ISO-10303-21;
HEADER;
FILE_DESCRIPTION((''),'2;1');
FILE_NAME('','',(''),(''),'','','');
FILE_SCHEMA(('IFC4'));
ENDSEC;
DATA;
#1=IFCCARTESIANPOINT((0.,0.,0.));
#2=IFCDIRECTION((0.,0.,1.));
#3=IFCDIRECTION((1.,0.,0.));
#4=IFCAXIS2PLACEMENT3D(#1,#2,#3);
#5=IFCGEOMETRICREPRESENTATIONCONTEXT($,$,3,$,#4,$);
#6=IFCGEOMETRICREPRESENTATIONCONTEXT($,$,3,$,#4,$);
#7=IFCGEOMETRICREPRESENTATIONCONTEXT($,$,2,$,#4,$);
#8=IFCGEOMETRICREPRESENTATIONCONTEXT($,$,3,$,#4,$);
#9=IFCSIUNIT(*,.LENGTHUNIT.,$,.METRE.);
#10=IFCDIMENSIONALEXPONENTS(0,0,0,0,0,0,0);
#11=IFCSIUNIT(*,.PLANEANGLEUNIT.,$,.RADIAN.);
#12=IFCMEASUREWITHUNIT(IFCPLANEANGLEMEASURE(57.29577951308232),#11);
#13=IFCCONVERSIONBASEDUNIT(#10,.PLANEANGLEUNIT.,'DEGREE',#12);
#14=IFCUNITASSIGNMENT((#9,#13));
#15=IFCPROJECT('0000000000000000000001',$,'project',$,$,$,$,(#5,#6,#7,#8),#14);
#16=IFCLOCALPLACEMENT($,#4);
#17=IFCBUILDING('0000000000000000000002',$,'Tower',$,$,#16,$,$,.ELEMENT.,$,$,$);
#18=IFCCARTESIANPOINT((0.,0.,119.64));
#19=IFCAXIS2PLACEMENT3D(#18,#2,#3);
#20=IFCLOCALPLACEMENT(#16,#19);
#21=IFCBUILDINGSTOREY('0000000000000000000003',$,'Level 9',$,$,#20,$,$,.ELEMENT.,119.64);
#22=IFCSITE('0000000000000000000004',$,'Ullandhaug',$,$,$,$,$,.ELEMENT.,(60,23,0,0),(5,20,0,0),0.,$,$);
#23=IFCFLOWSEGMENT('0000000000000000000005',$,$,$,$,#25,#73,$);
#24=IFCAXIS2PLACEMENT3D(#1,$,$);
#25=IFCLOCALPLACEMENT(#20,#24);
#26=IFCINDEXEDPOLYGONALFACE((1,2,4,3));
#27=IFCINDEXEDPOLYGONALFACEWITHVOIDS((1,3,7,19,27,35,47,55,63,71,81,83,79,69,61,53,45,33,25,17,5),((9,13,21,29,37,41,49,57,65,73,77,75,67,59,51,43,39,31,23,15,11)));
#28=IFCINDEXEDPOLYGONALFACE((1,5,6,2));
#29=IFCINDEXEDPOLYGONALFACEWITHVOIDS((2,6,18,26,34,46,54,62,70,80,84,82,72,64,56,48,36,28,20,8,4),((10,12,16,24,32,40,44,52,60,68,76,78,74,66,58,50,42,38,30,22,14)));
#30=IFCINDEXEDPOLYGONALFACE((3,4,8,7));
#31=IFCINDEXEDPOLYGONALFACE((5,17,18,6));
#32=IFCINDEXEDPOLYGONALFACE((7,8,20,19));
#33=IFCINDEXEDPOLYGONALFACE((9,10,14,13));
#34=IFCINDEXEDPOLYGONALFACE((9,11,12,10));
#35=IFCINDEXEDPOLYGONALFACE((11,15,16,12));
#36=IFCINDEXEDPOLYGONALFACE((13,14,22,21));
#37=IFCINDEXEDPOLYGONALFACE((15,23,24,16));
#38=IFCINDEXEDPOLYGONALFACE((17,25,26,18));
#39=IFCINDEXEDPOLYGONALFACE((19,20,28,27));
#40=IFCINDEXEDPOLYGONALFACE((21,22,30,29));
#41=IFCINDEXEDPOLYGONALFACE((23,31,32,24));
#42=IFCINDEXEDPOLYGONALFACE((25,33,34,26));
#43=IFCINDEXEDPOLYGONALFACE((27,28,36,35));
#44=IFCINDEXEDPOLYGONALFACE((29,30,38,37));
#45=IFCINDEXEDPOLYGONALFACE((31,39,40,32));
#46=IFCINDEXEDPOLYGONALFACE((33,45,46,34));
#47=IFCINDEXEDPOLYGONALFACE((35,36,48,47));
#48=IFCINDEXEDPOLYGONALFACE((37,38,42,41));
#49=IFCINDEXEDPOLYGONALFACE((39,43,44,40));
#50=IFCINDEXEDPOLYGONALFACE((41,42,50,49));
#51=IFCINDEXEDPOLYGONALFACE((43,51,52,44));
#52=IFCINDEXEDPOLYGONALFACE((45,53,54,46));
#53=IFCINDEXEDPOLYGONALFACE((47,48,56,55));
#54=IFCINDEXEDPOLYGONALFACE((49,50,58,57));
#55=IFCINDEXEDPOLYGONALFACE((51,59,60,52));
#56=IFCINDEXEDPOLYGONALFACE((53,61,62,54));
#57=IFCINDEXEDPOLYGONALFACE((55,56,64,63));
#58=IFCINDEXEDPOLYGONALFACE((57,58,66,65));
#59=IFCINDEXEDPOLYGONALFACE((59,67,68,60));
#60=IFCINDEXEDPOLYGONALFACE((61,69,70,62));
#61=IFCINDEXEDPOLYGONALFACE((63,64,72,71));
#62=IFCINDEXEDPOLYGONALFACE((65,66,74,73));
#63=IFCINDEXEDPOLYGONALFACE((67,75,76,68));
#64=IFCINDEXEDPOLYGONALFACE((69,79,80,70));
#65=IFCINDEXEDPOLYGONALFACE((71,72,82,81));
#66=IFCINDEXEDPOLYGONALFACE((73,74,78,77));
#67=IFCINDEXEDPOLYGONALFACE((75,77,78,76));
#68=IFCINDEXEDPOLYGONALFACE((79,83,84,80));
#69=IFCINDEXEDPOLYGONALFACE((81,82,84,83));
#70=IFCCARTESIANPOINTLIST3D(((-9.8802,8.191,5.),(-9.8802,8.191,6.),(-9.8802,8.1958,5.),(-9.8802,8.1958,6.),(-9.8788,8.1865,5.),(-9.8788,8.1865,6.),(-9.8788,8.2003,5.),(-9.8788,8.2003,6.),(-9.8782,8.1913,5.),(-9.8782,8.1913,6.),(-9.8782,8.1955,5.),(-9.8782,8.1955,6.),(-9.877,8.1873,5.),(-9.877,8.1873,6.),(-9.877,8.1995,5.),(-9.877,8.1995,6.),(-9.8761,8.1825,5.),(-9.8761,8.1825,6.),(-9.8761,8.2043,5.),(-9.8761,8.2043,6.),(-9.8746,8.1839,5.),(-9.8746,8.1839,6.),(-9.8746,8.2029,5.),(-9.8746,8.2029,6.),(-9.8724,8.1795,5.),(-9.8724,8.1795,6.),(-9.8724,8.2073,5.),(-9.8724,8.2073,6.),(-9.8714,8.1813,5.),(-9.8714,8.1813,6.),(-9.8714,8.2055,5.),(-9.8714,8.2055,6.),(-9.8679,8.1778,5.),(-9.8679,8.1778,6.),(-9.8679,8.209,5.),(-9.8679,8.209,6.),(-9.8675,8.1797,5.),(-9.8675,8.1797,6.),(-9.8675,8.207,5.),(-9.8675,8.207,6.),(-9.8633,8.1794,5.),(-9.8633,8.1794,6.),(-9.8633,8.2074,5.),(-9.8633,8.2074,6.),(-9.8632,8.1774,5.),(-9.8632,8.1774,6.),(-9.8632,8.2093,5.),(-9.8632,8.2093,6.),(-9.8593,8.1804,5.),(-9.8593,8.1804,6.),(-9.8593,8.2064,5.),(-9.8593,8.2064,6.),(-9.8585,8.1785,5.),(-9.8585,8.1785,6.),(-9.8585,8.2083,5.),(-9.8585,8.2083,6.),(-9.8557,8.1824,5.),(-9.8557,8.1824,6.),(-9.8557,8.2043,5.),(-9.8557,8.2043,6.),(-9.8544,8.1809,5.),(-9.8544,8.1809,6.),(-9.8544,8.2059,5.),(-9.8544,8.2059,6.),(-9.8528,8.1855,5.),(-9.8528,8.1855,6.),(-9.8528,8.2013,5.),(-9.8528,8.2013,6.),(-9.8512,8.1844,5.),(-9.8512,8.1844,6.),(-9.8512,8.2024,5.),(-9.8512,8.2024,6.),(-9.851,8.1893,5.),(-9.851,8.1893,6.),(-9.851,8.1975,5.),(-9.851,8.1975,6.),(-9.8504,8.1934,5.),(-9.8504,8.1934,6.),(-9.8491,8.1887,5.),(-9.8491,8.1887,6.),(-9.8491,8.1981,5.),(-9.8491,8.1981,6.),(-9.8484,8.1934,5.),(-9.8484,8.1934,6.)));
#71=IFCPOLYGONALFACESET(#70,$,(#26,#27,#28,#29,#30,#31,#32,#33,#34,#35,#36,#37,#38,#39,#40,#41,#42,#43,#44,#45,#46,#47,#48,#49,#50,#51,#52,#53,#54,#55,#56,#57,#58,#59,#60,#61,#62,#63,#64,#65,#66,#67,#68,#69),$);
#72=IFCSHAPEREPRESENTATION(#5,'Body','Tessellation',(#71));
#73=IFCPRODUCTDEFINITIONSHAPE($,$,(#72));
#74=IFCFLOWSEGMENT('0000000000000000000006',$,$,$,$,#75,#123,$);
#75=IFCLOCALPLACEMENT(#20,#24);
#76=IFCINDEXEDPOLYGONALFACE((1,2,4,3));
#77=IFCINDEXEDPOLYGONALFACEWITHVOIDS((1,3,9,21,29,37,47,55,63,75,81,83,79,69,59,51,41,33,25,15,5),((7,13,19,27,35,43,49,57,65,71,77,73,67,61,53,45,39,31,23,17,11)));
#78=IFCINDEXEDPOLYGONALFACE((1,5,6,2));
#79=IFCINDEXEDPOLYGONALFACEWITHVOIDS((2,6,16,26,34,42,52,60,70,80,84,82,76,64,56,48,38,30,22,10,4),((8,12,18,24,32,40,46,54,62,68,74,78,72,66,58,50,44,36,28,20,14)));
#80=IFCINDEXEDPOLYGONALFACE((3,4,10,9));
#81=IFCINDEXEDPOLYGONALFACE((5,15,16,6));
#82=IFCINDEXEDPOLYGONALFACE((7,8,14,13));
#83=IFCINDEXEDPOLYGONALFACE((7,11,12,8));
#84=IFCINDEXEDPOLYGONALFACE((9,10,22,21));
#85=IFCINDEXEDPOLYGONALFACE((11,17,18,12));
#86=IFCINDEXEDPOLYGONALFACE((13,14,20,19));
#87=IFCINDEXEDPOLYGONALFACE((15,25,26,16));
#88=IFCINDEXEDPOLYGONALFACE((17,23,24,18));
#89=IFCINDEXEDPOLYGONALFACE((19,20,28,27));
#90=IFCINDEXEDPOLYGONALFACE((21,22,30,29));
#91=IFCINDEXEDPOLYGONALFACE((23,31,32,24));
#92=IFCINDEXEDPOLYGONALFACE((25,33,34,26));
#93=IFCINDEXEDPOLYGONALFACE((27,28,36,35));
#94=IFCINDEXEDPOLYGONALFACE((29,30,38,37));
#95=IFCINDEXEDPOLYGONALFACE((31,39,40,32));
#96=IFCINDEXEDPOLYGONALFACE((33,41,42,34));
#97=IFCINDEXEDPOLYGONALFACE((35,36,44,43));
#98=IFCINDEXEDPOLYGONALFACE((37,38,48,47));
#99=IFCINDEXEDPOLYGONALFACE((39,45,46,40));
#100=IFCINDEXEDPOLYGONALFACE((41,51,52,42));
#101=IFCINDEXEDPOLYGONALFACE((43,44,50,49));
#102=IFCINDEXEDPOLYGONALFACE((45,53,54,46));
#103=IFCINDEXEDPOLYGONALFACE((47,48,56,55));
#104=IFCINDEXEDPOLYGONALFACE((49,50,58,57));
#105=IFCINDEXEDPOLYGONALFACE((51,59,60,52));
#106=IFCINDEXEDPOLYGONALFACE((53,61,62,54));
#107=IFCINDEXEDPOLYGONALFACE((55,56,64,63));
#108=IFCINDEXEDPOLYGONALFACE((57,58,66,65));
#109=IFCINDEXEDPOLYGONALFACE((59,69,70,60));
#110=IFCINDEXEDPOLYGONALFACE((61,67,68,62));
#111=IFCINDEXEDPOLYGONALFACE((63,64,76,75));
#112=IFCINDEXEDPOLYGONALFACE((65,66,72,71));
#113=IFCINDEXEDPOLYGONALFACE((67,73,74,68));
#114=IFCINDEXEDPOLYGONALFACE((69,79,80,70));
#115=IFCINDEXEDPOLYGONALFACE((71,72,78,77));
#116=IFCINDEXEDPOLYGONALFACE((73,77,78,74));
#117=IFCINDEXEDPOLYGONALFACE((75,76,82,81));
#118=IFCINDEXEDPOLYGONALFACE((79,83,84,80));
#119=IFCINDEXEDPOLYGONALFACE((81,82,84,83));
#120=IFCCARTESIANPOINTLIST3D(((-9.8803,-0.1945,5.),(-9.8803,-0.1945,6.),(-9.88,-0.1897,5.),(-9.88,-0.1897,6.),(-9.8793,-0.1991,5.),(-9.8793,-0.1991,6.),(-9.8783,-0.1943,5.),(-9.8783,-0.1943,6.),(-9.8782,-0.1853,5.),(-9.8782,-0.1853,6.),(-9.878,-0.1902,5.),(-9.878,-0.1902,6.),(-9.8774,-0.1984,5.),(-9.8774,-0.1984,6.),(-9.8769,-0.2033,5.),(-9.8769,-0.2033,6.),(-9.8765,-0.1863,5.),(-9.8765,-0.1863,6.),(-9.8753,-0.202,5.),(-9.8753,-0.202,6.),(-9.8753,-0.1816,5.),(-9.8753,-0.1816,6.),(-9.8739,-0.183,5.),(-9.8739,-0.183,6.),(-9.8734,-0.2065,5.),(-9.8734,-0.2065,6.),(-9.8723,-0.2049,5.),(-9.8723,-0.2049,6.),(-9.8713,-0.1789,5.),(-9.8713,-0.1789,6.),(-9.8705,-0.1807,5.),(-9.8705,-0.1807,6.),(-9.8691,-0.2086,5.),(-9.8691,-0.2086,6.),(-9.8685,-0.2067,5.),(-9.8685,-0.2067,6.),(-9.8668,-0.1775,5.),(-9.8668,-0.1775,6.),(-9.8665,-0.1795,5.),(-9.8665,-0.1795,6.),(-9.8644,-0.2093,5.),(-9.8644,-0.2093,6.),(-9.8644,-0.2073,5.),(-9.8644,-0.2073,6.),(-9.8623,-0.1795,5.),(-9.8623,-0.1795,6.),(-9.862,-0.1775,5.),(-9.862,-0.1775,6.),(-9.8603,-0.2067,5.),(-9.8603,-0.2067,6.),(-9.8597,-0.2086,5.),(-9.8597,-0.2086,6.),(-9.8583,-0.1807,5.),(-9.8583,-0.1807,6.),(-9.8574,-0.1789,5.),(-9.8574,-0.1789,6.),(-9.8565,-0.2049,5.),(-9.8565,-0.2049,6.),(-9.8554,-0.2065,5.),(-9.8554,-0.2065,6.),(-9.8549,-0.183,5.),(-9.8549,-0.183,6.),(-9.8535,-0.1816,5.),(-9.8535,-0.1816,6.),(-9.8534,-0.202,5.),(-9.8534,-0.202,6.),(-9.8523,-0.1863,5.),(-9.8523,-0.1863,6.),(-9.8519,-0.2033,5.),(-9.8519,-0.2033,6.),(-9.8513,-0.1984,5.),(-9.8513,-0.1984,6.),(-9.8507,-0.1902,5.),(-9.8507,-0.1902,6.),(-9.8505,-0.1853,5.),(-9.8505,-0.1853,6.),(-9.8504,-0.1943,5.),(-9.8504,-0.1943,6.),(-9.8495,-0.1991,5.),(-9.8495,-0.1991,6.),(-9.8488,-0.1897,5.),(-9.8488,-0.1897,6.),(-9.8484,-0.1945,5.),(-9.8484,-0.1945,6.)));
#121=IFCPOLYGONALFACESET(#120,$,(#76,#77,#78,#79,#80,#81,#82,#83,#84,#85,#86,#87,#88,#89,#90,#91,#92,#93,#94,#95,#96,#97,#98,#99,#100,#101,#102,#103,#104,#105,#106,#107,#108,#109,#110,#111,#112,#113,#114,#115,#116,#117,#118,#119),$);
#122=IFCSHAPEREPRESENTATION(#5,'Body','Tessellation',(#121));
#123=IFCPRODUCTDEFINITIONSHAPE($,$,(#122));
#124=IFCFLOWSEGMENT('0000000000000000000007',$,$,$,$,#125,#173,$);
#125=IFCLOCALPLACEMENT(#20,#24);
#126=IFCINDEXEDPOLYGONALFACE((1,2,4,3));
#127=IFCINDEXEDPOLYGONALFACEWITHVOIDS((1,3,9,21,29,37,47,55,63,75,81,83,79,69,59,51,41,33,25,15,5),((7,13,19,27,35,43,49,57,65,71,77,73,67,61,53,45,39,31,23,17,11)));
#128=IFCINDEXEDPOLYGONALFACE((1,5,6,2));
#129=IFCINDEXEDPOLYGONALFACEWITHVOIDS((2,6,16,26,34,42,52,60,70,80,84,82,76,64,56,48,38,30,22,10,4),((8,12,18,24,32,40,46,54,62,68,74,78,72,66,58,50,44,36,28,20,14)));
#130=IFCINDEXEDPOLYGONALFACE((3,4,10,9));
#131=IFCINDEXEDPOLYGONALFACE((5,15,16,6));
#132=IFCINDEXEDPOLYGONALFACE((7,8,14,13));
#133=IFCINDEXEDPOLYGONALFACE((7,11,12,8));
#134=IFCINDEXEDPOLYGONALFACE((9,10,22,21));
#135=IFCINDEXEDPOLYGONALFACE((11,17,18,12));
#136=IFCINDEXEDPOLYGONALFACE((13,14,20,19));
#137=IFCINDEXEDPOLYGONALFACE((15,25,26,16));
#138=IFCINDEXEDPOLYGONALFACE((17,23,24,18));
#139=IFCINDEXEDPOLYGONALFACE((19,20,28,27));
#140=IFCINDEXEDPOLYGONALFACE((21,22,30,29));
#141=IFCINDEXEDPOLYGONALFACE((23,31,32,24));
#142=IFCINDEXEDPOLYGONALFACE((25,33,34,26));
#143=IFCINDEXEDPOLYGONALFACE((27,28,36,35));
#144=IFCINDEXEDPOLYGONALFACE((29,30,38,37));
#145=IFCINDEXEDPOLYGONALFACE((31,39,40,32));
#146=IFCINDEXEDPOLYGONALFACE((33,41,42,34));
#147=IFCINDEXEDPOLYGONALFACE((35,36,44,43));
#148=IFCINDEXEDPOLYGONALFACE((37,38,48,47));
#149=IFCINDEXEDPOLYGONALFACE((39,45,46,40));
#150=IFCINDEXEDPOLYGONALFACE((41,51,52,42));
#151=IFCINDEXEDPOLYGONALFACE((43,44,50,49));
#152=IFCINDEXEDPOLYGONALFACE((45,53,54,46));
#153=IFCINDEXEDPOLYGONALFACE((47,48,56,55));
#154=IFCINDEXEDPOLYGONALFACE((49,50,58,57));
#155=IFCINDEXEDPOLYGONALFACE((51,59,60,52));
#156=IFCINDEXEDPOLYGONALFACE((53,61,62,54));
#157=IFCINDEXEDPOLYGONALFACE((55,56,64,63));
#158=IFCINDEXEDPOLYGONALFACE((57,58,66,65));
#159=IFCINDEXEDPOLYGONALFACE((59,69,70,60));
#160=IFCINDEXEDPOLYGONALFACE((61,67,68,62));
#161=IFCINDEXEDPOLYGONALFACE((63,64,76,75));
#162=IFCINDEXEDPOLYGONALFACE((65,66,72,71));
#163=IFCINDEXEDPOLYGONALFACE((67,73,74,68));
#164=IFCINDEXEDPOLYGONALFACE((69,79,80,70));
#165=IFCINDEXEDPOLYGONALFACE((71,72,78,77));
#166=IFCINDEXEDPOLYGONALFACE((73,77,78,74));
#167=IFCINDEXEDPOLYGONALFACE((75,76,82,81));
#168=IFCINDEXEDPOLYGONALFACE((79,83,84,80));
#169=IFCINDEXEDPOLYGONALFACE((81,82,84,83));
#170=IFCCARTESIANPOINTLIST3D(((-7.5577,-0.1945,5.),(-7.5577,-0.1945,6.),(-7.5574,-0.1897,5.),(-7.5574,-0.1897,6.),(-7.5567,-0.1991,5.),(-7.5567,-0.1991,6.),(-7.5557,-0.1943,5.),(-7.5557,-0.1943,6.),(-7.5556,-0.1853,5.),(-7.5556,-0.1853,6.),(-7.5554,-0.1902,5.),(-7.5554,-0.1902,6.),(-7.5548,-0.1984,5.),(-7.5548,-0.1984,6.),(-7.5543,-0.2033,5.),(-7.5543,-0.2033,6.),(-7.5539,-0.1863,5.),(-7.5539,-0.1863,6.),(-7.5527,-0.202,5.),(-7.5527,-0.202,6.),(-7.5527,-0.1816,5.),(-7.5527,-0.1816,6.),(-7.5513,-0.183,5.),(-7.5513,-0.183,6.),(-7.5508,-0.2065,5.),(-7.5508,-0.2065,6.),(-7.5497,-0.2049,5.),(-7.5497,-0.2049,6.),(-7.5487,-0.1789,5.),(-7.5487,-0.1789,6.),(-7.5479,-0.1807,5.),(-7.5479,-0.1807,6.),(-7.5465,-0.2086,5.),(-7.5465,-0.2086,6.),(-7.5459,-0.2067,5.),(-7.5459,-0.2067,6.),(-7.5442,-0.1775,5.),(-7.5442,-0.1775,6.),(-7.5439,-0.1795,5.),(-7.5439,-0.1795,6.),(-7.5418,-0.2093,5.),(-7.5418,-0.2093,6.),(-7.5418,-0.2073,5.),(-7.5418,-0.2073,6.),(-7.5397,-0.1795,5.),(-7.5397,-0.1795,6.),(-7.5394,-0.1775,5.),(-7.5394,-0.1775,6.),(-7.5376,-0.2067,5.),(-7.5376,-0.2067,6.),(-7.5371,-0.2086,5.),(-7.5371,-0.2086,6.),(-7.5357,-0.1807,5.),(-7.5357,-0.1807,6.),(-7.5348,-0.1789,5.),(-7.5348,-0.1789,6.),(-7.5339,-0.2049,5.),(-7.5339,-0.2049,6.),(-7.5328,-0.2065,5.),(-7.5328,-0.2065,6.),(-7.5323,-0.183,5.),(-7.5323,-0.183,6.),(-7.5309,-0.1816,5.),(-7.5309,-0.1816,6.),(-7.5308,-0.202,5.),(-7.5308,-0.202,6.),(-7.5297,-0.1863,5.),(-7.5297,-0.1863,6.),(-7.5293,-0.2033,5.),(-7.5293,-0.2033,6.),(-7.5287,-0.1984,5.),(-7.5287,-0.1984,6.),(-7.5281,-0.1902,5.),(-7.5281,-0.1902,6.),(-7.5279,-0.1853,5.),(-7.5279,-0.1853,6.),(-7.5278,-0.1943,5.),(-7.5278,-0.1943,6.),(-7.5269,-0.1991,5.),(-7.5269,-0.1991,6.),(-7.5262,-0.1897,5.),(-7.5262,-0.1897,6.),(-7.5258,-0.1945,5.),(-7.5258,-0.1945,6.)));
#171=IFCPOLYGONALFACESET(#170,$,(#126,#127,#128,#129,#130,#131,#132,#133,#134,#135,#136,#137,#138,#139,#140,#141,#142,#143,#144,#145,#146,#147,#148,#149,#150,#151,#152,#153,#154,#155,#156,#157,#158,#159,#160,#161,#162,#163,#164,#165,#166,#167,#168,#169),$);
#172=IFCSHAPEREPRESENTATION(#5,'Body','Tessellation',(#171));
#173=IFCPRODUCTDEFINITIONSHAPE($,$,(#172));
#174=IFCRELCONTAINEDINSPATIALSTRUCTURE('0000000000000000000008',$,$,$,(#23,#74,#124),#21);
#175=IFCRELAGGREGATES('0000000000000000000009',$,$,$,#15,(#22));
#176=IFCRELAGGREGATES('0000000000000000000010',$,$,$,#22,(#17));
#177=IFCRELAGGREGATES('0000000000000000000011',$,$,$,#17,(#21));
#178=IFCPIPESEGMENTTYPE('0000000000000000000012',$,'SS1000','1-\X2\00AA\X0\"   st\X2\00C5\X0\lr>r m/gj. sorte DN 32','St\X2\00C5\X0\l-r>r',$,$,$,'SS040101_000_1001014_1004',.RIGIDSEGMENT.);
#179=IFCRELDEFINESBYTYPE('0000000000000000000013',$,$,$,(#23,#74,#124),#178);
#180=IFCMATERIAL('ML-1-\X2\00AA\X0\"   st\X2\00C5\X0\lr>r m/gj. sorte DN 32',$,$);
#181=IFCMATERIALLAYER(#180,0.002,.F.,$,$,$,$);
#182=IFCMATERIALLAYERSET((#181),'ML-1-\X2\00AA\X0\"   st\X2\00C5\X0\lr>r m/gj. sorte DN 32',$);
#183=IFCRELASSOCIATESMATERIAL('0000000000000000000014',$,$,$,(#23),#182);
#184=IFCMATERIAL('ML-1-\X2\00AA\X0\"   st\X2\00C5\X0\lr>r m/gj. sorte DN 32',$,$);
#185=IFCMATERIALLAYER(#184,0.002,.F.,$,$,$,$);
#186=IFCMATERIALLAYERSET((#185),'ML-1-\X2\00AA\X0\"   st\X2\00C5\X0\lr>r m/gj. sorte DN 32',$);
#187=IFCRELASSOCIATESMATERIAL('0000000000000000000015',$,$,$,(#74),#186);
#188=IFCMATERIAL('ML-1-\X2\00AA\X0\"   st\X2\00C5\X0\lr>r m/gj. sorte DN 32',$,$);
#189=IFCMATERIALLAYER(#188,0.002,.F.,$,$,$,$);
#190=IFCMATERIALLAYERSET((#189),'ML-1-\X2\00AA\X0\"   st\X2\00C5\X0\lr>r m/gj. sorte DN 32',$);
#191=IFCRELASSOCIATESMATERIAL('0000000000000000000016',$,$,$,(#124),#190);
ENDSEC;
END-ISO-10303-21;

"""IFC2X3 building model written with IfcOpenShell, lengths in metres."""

from ifc_helpers import new_model, entity, si_unit, converted_unit, frame, origin_with_axes, origin_2d_with_axis, place, context, project, spatial, hollow_circle, extrude, material, layer, layer_set, layer_usage, type_object, element, save


model = new_model("IFC2X3")

# Units and contexts
context_of_model_1 = context(None, 3, world=origin_with_axes())
context_of_model_2 = context(None, 3, world=origin_with_axes())
context_of_model_3 = context(None, 2, world=origin_with_axes())
context_of_model_4 = context(None, 3, world=origin_with_axes())
ifc_project = project(units=[si_unit("LENGTHUNIT", "METRE"), converted_unit("PLANEANGLEUNIT", "DEGREE", entity("IfcPlaneAngleMeasure", 57.29577951308232), si_unit("PLANEANGLEUNIT", "RADIAN"), dimensions=[0, 0, 0, 0, 0, 0, 0])], contexts=[context_of_model_1, context_of_model_2, context_of_model_3, context_of_model_4])

# Site, building, storey
site = spatial("IfcSite", under=ifc_project, Name="Ullandhaug", CompositionType="ELEMENT", RefLatitude=(60, 23, 0, 0), RefLongitude=(5, 20, 0, 0), RefElevation=0.0)
building_placement = place(None, origin_with_axes())
building = spatial("IfcBuilding", under=site, at=building_placement, Name="Tower", CompositionType="ELEMENT")
storey_placement = place(building_placement, frame((0.0, 0.0, 119.64), z_axis=(0.0, 0.0, 1.0), x_axis=(1.0, 0.0, 0.0)))
storey = spatial("IfcBuildingStorey", under=building, at=storey_placement, Name="Level 9", CompositionType="ELEMENT", Elevation=119.64)

# Flow segments
pipe_segment_type_1 = type_object("IfcPipeSegmentType", Name="SS1000", Description="1-ª\"   stÅlr>r m/gj. sorte DN 32", ApplicableOccurrence="StÅl-r>r", ElementType="SS040101_000_1001014_1004", PredefinedType="RIGIDSEGMENT")
ifc_material_1 = material(Name="ML-1-ª\"   stÅlr>r m/gj. sorte DN 32")
ifc_layer_1 = layer(ifc_material_1, 0.002, ventilated=False)
ifc_layer_set_1 = layer_set([ifc_layer_1], Name="ML-1-ª\"   stÅlr>r m/gj. sorte DN 32")
ifc_layer_usage_1 = layer_usage(ifc_layer_set_1, "AXIS2", "POSITIVE", 0.0)
flow_segment_1_placement = place(storey_placement, frame((-9.8644, 8.1934, 5.0), z_axis=(0.0, 0.0, 1.0), x_axis=(1.0, 0.0, 0.0)))
element("IfcFlowSegment", 1, at=flow_segment_1_placement, inside=storey, type_object=pipe_segment_type_1, material=ifc_layer_usage_1, context=context_of_model_1, shape_type="SweptSolid", body=[
    extrude(hollow_circle(Radius=0.016, WallThickness=0.002, at=origin_2d_with_axis()), origin_with_axes(), (0.0, 0.0, 1.0), 1.0),
])
ifc_material_2 = material(Name="ML-1-ª\"   stÅlr>r m/gj. sorte DN 32")
ifc_layer_2 = layer(ifc_material_2, 0.002, ventilated=False)
ifc_layer_set_2 = layer_set([ifc_layer_2], Name="ML-1-ª\"   stÅlr>r m/gj. sorte DN 32")
ifc_layer_usage_2 = layer_usage(ifc_layer_set_2, "AXIS2", "POSITIVE", 0.0)
flow_segment_2_placement = place(storey_placement, frame((-9.8644, -0.1933, 5.0), z_axis=(0.0, 0.0, 1.0), x_axis=(0.0, -1.0, 0.0)))
element("IfcFlowSegment", 2, at=flow_segment_2_placement, inside=storey, type_object=pipe_segment_type_1, material=ifc_layer_usage_2, context=context_of_model_1, shape_type="SweptSolid", body=[
    extrude(hollow_circle(Radius=0.016, WallThickness=0.002, at=origin_2d_with_axis()), origin_with_axes(), (0.0, 0.0, 1.0), 1.0),
])
ifc_material_3 = material(Name="ML-1-ª\"   stÅlr>r m/gj. sorte DN 32")
ifc_layer_3 = layer(ifc_material_3, 0.002, ventilated=False)
ifc_layer_set_3 = layer_set([ifc_layer_3], Name="ML-1-ª\"   stÅlr>r m/gj. sorte DN 32")
ifc_layer_usage_3 = layer_usage(ifc_layer_set_3, "AXIS2", "POSITIVE", 0.0)
flow_segment_3_placement = place(storey_placement, frame((-7.5418, -0.1933, 5.0), z_axis=(0.0, 0.0, 1.0), x_axis=(0.0, -1.0, 0.0)))
element("IfcFlowSegment", 3, at=flow_segment_3_placement, inside=storey, type_object=pipe_segment_type_1, material=ifc_layer_usage_3, context=context_of_model_1, shape_type="SweptSolid", body=[
    extrude(hollow_circle(Radius=0.016, WallThickness=0.002, at=origin_2d_with_axis()), origin_with_axes(), (0.0, 0.0, 1.0), 1.0),
])

save(model, "model.ifc")
